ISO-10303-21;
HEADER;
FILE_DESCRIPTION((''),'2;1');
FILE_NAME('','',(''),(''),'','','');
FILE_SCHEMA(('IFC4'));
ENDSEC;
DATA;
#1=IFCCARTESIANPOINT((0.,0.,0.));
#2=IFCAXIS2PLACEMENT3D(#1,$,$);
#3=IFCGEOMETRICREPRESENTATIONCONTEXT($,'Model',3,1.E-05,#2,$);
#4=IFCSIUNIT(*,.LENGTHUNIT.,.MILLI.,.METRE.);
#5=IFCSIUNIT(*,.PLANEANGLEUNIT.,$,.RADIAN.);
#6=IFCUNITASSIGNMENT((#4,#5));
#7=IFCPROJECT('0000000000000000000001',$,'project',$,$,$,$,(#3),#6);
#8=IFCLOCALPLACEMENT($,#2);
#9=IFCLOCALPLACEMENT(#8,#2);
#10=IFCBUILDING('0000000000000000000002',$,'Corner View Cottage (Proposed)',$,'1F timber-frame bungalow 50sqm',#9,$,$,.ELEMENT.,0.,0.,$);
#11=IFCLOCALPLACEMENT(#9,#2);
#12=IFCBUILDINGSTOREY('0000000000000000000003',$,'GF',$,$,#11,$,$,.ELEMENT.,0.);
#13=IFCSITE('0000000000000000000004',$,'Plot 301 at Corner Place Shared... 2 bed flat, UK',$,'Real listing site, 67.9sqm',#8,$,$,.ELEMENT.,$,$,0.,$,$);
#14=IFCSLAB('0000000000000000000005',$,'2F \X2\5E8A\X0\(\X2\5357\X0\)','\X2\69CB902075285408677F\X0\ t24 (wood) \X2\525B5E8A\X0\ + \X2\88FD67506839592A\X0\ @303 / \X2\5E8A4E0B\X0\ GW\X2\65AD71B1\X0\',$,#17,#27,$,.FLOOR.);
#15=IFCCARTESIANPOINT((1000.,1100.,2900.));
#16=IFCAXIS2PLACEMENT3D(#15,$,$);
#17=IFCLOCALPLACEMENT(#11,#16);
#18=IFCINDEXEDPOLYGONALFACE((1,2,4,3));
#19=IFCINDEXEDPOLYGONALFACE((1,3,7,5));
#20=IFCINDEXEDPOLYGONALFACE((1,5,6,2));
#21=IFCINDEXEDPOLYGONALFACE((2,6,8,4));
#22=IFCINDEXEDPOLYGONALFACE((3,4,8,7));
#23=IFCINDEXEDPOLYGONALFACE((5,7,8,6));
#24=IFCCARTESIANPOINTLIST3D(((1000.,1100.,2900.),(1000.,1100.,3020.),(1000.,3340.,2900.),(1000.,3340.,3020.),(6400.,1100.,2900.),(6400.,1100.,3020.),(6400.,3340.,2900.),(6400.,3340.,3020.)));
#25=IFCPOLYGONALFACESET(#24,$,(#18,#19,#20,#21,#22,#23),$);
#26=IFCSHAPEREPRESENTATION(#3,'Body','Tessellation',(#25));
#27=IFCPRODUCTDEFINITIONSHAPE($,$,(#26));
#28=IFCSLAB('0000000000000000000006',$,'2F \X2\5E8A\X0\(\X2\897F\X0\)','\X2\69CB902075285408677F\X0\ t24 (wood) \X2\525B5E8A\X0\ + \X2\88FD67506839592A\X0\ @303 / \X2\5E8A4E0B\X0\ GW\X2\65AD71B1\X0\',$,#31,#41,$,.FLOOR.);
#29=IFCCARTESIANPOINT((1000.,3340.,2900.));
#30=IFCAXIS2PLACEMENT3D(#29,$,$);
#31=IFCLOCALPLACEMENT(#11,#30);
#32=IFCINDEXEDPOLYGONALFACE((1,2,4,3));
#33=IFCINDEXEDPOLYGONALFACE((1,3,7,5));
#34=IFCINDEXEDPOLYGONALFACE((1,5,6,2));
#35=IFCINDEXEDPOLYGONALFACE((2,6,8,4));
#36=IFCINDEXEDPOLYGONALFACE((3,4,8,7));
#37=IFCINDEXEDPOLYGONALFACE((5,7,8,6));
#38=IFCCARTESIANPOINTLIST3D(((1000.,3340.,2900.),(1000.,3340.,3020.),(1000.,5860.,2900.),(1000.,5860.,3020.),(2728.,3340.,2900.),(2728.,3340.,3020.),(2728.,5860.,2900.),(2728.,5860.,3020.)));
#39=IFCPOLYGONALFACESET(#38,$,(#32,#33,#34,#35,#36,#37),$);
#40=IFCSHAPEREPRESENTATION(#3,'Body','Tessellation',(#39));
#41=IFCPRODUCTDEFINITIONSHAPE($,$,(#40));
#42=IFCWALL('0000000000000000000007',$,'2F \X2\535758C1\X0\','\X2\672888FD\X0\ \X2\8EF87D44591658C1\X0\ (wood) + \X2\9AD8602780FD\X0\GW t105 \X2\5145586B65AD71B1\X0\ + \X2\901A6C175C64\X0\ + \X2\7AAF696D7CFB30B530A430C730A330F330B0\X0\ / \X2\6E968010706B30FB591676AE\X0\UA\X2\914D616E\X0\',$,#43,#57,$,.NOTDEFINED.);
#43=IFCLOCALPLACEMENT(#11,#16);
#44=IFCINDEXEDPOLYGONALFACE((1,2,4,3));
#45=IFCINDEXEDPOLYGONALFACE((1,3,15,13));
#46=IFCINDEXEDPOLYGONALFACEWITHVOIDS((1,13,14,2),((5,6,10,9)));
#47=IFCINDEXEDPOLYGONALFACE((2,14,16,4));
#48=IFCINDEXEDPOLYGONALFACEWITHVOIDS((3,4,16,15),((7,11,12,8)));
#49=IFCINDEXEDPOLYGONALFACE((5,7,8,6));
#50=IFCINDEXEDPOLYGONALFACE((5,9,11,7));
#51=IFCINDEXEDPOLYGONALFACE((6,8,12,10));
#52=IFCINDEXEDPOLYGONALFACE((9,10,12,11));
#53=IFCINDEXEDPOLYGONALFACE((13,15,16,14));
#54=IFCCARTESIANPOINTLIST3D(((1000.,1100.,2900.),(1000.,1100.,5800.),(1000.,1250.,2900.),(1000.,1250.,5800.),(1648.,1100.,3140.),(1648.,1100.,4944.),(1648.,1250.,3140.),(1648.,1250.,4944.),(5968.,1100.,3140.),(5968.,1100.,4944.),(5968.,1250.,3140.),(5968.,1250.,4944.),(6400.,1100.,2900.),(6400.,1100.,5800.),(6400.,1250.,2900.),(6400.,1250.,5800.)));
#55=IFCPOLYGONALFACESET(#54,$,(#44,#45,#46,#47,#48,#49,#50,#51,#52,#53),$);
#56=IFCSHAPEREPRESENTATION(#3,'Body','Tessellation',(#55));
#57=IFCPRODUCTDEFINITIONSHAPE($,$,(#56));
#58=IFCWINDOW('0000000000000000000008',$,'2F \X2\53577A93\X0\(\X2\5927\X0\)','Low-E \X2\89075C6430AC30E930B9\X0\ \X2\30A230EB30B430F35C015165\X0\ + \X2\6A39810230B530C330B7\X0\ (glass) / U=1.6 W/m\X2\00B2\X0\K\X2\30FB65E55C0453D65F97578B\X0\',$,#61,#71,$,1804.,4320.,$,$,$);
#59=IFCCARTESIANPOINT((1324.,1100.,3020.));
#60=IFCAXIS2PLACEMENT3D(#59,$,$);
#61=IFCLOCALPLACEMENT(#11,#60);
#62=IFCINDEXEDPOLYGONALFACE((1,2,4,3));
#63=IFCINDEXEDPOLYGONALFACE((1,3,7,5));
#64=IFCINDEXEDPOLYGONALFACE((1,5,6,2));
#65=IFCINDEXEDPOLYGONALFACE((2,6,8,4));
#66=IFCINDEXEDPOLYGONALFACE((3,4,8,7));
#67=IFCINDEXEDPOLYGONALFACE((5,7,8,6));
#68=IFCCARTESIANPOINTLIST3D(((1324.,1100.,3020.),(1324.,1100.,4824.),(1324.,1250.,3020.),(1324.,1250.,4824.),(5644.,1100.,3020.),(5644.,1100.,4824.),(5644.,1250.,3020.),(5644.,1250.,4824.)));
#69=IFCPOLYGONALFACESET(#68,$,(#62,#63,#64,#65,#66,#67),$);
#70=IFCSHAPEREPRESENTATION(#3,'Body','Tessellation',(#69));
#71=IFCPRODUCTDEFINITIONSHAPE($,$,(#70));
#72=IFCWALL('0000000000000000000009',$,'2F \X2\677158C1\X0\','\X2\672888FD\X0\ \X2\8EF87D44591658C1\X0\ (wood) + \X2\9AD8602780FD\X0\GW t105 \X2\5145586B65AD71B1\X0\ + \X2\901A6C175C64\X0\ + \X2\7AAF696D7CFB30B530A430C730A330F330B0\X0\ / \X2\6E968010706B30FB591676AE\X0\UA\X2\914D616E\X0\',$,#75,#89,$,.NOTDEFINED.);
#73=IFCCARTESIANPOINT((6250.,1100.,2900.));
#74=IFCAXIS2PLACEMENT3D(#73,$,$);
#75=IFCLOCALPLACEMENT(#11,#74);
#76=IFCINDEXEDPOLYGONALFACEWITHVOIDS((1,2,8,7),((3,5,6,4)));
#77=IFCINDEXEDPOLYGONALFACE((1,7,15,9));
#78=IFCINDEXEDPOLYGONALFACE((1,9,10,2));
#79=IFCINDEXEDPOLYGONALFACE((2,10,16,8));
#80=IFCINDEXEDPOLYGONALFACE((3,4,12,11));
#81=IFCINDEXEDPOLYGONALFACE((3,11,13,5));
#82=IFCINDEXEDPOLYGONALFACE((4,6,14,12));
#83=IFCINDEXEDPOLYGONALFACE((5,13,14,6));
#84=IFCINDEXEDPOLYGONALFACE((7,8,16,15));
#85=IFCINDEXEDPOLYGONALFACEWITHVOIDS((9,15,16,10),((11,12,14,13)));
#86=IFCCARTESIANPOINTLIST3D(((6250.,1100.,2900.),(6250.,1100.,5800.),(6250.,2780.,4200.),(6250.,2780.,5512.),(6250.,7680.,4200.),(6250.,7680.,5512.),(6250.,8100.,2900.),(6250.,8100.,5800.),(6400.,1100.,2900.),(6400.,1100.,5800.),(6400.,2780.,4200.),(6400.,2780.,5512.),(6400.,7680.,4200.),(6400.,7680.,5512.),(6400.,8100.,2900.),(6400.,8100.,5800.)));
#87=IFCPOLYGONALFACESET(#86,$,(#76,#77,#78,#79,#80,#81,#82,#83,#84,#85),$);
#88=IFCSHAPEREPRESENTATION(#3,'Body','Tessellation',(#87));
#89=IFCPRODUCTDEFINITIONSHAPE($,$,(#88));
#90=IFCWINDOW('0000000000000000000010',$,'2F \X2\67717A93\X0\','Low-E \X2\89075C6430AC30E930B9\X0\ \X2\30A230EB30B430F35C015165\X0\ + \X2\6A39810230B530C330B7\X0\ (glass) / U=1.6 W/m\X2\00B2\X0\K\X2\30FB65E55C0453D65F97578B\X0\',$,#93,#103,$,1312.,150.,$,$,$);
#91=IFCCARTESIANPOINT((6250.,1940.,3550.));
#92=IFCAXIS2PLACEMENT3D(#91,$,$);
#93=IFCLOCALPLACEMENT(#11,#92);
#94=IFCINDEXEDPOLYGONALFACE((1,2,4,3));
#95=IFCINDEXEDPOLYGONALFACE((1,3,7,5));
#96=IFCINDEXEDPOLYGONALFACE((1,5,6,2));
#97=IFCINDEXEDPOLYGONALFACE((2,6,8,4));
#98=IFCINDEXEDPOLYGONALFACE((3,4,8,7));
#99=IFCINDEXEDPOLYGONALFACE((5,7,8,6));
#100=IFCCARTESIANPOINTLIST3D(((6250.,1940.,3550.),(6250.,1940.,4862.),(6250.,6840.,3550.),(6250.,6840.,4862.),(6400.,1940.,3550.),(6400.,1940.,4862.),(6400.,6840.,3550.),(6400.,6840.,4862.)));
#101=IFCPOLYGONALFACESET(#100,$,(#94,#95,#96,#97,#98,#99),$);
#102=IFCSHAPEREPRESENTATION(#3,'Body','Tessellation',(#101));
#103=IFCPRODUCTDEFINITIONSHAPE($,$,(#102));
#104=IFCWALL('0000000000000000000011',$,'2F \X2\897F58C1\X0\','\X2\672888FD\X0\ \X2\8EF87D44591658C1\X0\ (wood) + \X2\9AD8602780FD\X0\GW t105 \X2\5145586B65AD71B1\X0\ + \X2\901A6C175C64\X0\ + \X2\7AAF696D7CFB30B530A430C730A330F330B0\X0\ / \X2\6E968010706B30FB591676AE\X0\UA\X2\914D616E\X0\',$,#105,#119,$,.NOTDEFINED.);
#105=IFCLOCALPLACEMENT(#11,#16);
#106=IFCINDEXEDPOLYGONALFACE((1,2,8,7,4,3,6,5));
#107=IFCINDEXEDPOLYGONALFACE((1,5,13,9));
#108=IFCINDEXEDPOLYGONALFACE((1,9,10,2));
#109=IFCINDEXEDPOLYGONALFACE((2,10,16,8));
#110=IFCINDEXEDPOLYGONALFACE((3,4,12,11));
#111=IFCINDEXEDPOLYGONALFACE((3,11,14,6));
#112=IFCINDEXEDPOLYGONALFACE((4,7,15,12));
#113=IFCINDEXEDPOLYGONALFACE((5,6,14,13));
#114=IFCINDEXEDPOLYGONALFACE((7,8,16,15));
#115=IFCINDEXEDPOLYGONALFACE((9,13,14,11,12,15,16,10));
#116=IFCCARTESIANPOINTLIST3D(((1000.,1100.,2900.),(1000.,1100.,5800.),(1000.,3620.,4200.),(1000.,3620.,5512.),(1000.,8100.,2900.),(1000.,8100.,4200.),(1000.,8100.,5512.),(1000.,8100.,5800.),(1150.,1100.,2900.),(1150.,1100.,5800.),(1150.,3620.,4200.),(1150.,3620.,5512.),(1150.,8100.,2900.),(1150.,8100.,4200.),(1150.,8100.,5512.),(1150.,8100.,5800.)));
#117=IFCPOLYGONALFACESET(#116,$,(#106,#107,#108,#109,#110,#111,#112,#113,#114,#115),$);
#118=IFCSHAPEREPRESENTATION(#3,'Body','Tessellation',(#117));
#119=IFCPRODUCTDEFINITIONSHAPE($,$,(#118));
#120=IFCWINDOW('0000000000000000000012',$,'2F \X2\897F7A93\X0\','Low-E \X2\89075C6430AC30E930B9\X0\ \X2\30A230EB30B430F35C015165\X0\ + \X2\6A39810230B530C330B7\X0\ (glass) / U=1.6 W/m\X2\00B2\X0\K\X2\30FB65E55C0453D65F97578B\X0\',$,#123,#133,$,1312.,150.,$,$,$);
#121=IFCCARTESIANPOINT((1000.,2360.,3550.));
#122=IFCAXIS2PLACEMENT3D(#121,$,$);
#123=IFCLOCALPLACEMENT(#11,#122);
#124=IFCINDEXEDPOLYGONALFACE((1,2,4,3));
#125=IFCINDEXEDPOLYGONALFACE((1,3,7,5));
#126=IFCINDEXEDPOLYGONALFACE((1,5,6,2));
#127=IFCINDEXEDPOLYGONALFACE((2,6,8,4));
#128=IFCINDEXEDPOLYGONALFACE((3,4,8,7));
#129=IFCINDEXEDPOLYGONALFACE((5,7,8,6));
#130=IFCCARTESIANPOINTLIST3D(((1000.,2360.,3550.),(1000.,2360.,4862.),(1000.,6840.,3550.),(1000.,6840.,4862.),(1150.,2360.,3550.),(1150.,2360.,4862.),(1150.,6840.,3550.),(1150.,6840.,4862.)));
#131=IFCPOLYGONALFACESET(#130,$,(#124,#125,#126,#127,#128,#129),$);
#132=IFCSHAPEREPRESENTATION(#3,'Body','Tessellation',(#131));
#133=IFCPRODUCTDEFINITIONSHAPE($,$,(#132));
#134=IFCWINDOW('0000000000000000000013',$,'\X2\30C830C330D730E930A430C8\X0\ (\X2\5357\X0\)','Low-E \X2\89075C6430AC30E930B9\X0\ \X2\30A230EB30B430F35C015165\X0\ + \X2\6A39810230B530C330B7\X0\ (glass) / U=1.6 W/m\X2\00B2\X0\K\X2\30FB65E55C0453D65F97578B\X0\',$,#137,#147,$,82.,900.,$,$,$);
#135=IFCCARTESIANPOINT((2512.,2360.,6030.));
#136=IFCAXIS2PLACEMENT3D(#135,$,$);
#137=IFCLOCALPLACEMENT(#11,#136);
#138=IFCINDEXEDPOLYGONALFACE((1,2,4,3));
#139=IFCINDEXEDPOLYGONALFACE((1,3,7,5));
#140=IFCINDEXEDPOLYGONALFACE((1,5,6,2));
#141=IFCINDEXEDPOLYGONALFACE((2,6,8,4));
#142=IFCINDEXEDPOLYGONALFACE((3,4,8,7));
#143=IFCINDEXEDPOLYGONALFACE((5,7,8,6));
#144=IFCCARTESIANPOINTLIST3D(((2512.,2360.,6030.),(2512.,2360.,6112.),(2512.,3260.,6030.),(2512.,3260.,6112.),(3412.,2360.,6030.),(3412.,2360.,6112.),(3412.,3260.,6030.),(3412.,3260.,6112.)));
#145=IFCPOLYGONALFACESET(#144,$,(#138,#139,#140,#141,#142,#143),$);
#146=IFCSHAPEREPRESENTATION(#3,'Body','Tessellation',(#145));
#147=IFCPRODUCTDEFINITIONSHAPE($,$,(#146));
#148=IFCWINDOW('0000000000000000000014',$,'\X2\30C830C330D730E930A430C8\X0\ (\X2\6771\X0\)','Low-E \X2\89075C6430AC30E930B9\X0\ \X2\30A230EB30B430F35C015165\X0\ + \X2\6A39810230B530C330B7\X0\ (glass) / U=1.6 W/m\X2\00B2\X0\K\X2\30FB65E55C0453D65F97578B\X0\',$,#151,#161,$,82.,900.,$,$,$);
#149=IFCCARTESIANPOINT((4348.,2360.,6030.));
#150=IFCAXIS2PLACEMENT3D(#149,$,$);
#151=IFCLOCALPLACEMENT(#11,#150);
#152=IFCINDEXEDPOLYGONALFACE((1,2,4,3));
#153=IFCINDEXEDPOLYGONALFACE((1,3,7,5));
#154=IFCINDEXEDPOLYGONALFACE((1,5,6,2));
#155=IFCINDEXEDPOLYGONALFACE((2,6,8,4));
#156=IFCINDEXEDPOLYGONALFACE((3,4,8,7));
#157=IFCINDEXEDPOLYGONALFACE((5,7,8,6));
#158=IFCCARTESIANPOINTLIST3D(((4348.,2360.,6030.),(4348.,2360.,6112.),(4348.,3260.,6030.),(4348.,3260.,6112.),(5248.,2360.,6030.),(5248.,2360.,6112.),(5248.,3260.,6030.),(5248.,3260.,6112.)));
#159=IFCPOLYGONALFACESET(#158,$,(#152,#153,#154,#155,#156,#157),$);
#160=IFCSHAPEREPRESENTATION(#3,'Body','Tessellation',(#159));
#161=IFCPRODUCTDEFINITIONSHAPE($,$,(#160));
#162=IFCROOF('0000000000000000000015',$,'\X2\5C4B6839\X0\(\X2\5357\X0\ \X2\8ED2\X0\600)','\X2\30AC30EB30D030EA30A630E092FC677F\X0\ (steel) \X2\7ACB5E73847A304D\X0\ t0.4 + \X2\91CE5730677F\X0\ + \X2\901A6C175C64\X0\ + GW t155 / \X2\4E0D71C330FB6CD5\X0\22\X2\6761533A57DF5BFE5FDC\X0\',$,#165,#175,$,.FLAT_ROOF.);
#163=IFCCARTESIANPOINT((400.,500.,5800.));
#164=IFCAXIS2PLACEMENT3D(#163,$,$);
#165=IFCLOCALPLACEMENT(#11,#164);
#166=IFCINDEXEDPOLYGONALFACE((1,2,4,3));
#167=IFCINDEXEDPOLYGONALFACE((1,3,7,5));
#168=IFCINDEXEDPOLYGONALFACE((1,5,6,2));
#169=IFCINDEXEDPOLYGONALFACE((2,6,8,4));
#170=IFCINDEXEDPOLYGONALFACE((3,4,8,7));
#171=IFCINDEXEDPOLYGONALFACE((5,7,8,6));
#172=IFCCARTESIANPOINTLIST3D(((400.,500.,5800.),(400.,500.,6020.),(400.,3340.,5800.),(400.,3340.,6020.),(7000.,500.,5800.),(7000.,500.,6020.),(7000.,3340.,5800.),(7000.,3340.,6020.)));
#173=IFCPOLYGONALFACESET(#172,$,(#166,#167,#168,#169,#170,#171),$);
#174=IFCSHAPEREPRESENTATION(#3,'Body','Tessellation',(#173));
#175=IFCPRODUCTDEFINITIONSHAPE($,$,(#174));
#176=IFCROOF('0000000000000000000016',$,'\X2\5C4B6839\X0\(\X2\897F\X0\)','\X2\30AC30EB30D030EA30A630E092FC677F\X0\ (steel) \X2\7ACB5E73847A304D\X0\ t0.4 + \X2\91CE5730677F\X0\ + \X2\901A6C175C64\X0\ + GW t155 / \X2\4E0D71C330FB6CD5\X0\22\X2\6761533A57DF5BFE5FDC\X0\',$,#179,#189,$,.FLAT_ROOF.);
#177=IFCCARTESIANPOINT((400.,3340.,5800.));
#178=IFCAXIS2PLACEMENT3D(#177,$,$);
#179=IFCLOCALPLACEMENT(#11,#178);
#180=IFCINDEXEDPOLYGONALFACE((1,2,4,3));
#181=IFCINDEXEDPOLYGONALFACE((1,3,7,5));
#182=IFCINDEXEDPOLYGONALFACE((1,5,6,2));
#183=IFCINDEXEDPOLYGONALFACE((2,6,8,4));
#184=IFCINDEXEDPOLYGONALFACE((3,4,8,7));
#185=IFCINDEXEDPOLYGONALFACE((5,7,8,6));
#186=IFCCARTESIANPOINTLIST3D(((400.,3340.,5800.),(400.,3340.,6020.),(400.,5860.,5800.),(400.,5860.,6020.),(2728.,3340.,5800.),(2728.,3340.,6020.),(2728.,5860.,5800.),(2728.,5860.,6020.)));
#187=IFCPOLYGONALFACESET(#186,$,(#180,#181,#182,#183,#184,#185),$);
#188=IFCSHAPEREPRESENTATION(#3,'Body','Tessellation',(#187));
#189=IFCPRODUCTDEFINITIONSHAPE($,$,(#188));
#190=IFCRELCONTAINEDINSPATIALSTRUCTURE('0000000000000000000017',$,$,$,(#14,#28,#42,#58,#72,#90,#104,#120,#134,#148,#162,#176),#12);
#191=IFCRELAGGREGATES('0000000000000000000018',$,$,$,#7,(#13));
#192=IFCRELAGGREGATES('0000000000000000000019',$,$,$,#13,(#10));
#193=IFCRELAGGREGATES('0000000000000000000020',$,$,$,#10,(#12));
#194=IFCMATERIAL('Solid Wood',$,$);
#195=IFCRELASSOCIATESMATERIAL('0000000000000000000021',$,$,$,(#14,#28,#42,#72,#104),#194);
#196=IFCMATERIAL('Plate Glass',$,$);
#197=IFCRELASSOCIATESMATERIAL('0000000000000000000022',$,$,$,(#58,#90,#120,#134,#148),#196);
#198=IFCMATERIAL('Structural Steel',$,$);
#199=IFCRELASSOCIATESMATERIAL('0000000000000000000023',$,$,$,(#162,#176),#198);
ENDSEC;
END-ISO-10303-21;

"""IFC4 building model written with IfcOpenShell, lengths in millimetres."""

from ifc_helpers import new_model, si_unit, frame, frame_2d, origin, place, context, project, spatial, rectangle, extrude, material, element, fill, save


model = new_model("IFC4")

# Units and contexts
model_context = context("Model", 3, precision=1e-05, world=origin())
ifc_project = project(units=[si_unit("LENGTHUNIT", "METRE", prefix="MILLI"), si_unit("PLANEANGLEUNIT", "RADIAN")], contexts=[model_context])

# Site, building, storey
site_placement = place(None, origin())
site = spatial("IfcSite", under=ifc_project, at=site_placement, Name="Plot 301 at Corner Place Shared... 2 bed flat, UK", ObjectType="Real listing site, 67.9sqm", CompositionType="ELEMENT", RefElevation=0.0)
building_placement = place(site_placement, origin())
building = spatial("IfcBuilding", under=site, at=building_placement, Name="Corner View Cottage (Proposed)", ObjectType="1F timber-frame bungalow 50sqm", CompositionType="ELEMENT", ElevationOfRefHeight=0.0, ElevationOfTerrain=0.0)
storey_placement = place(building_placement, origin())
storey = spatial("IfcBuildingStorey", under=building, at=storey_placement, Name="GF", CompositionType="ELEMENT", Elevation=0.0)

# Slabs
ifc_material_1 = material(Name="Solid Wood")
slab_1_placement = place(storey_placement, frame((1000.0, 1100.0, 2900.0)))
element("IfcSlab", 1, at=slab_1_placement, inside=storey, material=ifc_material_1, Name="2F 床(南)", Description="構造用合板 t24 (wood) 剛床 + 製材根太 @303 / 床下 GW断熱", PredefinedType="FLOOR", context=model_context, shape_type="SweptSolid", body=[
    extrude(rectangle(XDim=5400.0, YDim=2240.0, at=frame_2d((2700.0, 1120.0))), frame((1000.0, 1100.0, 2900.0)), (0.0, 0.0, 1.0), 120.0),
])
slab_2_placement = place(storey_placement, frame((1000.0, 3340.0, 2900.0)))
element("IfcSlab", 2, at=slab_2_placement, inside=storey, material=ifc_material_1, Name="2F 床(西)", Description="構造用合板 t24 (wood) 剛床 + 製材根太 @303 / 床下 GW断熱", PredefinedType="FLOOR", context=model_context, shape_type="SweptSolid", body=[
    extrude(rectangle(XDim=1728.0, YDim=2520.0, at=frame_2d((864.0, 1260.0))), frame((1000.0, 3340.0, 2900.0)), (0.0, 0.0, 1.0), 120.0),
])

# Walls, openings, windows
wall_1_placement = place(storey_placement, frame((1000.0, 1100.0, 2900.0)))
wall_1 = element("IfcWall", 3, at=wall_1_placement, inside=storey, material=ifc_material_1, Name="2F 南壁", Description="木製 軸組外壁 (wood) + 高性能GW t105 充填断熱 + 通気層 + 窯業系サイディング / 準耐火・外皮UA配慮", PredefinedType="NOTDEFINED", context=model_context, shape_type="SweptSolid", body=[
    extrude(rectangle(XDim=5400.0, YDim=150.0, at=frame_2d((2700.0, 75.0))), frame((1000.0, 1100.0, 2900.0)), (0.0, 0.0, 1.0), 2900.0),
])
opening_1_placement = place(storey_placement, frame((1324.0, 1100.0, 3020.0)))
opening_1 = element("IfcOpeningElement", 4, at=opening_1_placement, cuts=wall_1, PredefinedType="NOTDEFINED", context=model_context, shape_type="SweptSolid", body=[
    extrude(rectangle(XDim=4320.0, YDim=150.0, at=frame_2d((2160.0, 75.0))), frame((1324.0, 1100.0, 3020.0)), (0.0, 0.0, 1.0), 1804.0),
])
ifc_material_2 = material(Name="Plate Glass")
window_1_placement = place(storey_placement, frame((1324.0, 1100.0, 3020.0)))
window_1 = element("IfcWindow", 5, at=window_1_placement, inside=storey, material=ifc_material_2, Name="2F 南窓(大)", Description="Low-E 複層ガラス アルゴン封入 + 樹脂サッシ (glass) / U=1.6 W/m²K・日射取得型", OverallHeight=1804.0, OverallWidth=4320.0, context=model_context, shape_type="SweptSolid", body=[
    extrude(rectangle(XDim=4320.0, YDim=150.0, at=frame_2d((2160.0, 75.0))), frame((1324.0, 1100.0, 3020.0)), (0.0, 0.0, 1.0), 1804.0),
])
fill(opening_1, window_1)
wall_2_placement = place(storey_placement, frame((6250.0, 1100.0, 2900.0)))
wall_2 = element("IfcWall", 6, at=wall_2_placement, inside=storey, material=ifc_material_1, Name="2F 東壁", Description="木製 軸組外壁 (wood) + 高性能GW t105 充填断熱 + 通気層 + 窯業系サイディング / 準耐火・外皮UA配慮", PredefinedType="NOTDEFINED", context=model_context, shape_type="SweptSolid", body=[
    extrude(rectangle(XDim=150.0, YDim=7000.0, at=frame_2d((75.0, 3500.0))), frame((6250.0, 1100.0, 2900.0)), (0.0, 0.0, 1.0), 2900.0),
])
opening_2_placement = place(storey_placement, frame((6250.0, 1940.0, 3550.0)))
opening_2 = element("IfcOpeningElement", 7, at=opening_2_placement, cuts=wall_2, PredefinedType="NOTDEFINED", context=model_context, shape_type="SweptSolid", body=[
    extrude(rectangle(XDim=150.0, YDim=4900.0, at=frame_2d((75.0, 2450.0))), frame((6250.0, 1940.0, 3550.0)), (0.0, 0.0, 1.0), 1312.0),
])
window_2_placement = place(storey_placement, frame((6250.0, 1940.0, 3550.0)))
window_2 = element("IfcWindow", 8, at=window_2_placement, inside=storey, material=ifc_material_2, Name="2F 東窓", Description="Low-E 複層ガラス アルゴン封入 + 樹脂サッシ (glass) / U=1.6 W/m²K・日射取得型", OverallHeight=1312.0, OverallWidth=150.0, context=model_context, shape_type="SweptSolid", body=[
    extrude(rectangle(XDim=150.0, YDim=4900.0, at=frame_2d((75.0, 2450.0))), frame((6250.0, 1940.0, 3550.0)), (0.0, 0.0, 1.0), 1312.0),
])
fill(opening_2, window_2)
wall_3_placement = place(storey_placement, frame((1000.0, 1100.0, 2900.0)))
wall_3 = element("IfcWall", 9, at=wall_3_placement, inside=storey, material=ifc_material_1, Name="2F 西壁", Description="木製 軸組外壁 (wood) + 高性能GW t105 充填断熱 + 通気層 + 窯業系サイディング / 準耐火・外皮UA配慮", PredefinedType="NOTDEFINED", context=model_context, shape_type="SweptSolid", body=[
    extrude(rectangle(XDim=150.0, YDim=7000.0, at=frame_2d((75.0, 3500.0))), frame((1000.0, 1100.0, 2900.0)), (0.0, 0.0, 1.0), 2900.0),
])
opening_3_placement = place(storey_placement, frame((1000.0, 2360.0, 3550.0)))
opening_3 = element("IfcOpeningElement", 10, at=opening_3_placement, cuts=wall_3, PredefinedType="NOTDEFINED", context=model_context, shape_type="SweptSolid", body=[
    extrude(rectangle(XDim=150.0, YDim=4480.0, at=frame_2d((75.0, 2240.0))), frame((1000.0, 2360.0, 3550.0)), (0.0, 0.0, 1.0), 1312.0),
])
window_3_placement = place(storey_placement, frame((1000.0, 2360.0, 3550.0)))
window_3 = element("IfcWindow", 11, at=window_3_placement, inside=storey, material=ifc_material_2, Name="2F 西窓", Description="Low-E 複層ガラス アルゴン封入 + 樹脂サッシ (glass) / U=1.6 W/m²K・日射取得型", OverallHeight=1312.0, OverallWidth=150.0, context=model_context, shape_type="SweptSolid", body=[
    extrude(rectangle(XDim=150.0, YDim=4480.0, at=frame_2d((75.0, 2240.0))), frame((1000.0, 2360.0, 3550.0)), (0.0, 0.0, 1.0), 1312.0),
])
fill(opening_3, window_3)

# Windows
window_4_placement = place(storey_placement, frame((2512.0, 2360.0, 6030.0)))
element("IfcWindow", 12, at=window_4_placement, inside=storey, material=ifc_material_2, Name="トップライト (南)", Description="Low-E 複層ガラス アルゴン封入 + 樹脂サッシ (glass) / U=1.6 W/m²K・日射取得型", OverallHeight=82.0, OverallWidth=900.0, context=model_context, shape_type="SweptSolid", body=[
    extrude(rectangle(XDim=900.0, YDim=900.0, at=frame_2d((450.0, 450.0))), frame((2512.0, 2360.0, 6030.0)), (0.0, 0.0, 1.0), 82.0),
])
window_5_placement = place(storey_placement, frame((4348.0, 2360.0, 6030.0)))
element("IfcWindow", 13, at=window_5_placement, inside=storey, material=ifc_material_2, Name="トップライト (東)", Description="Low-E 複層ガラス アルゴン封入 + 樹脂サッシ (glass) / U=1.6 W/m²K・日射取得型", OverallHeight=82.0, OverallWidth=900.0, context=model_context, shape_type="SweptSolid", body=[
    extrude(rectangle(XDim=900.0, YDim=900.0, at=frame_2d((450.0, 450.0))), frame((4348.0, 2360.0, 6030.0)), (0.0, 0.0, 1.0), 82.0),
])

# Roofs
ifc_material_3 = material(Name="Structural Steel")
roof_1_placement = place(storey_placement, frame((400.0, 500.0, 5800.0)))
element("IfcRoof", 14, at=roof_1_placement, inside=storey, material=ifc_material_3, Name="屋根(南 軒600)", Description="ガルバリウム鋼板 (steel) 立平葺き t0.4 + 野地板 + 通気層 + GW t155 / 不燃・法22条区域対応", PredefinedType="FLAT_ROOF", context=model_context, shape_type="SweptSolid", body=[
    extrude(rectangle(XDim=6600.0, YDim=2840.0, at=frame_2d((3300.0, 1420.0))), frame((400.0, 500.0, 5800.0)), (0.0, 0.0, 1.0), 220.0),
])
roof_2_placement = place(storey_placement, frame((400.0, 3340.0, 5800.0)))
element("IfcRoof", 15, at=roof_2_placement, inside=storey, material=ifc_material_3, Name="屋根(西)", Description="ガルバリウム鋼板 (steel) 立平葺き t0.4 + 野地板 + 通気層 + GW t155 / 不燃・法22条区域対応", PredefinedType="FLAT_ROOF", context=model_context, shape_type="SweptSolid", body=[
    extrude(rectangle(XDim=2328.0, YDim=2520.0, at=frame_2d((1164.0, 1260.0))), frame((400.0, 3340.0, 5800.0)), (0.0, 0.0, 1.0), 220.0),
])

save(model, "model.ifc")
